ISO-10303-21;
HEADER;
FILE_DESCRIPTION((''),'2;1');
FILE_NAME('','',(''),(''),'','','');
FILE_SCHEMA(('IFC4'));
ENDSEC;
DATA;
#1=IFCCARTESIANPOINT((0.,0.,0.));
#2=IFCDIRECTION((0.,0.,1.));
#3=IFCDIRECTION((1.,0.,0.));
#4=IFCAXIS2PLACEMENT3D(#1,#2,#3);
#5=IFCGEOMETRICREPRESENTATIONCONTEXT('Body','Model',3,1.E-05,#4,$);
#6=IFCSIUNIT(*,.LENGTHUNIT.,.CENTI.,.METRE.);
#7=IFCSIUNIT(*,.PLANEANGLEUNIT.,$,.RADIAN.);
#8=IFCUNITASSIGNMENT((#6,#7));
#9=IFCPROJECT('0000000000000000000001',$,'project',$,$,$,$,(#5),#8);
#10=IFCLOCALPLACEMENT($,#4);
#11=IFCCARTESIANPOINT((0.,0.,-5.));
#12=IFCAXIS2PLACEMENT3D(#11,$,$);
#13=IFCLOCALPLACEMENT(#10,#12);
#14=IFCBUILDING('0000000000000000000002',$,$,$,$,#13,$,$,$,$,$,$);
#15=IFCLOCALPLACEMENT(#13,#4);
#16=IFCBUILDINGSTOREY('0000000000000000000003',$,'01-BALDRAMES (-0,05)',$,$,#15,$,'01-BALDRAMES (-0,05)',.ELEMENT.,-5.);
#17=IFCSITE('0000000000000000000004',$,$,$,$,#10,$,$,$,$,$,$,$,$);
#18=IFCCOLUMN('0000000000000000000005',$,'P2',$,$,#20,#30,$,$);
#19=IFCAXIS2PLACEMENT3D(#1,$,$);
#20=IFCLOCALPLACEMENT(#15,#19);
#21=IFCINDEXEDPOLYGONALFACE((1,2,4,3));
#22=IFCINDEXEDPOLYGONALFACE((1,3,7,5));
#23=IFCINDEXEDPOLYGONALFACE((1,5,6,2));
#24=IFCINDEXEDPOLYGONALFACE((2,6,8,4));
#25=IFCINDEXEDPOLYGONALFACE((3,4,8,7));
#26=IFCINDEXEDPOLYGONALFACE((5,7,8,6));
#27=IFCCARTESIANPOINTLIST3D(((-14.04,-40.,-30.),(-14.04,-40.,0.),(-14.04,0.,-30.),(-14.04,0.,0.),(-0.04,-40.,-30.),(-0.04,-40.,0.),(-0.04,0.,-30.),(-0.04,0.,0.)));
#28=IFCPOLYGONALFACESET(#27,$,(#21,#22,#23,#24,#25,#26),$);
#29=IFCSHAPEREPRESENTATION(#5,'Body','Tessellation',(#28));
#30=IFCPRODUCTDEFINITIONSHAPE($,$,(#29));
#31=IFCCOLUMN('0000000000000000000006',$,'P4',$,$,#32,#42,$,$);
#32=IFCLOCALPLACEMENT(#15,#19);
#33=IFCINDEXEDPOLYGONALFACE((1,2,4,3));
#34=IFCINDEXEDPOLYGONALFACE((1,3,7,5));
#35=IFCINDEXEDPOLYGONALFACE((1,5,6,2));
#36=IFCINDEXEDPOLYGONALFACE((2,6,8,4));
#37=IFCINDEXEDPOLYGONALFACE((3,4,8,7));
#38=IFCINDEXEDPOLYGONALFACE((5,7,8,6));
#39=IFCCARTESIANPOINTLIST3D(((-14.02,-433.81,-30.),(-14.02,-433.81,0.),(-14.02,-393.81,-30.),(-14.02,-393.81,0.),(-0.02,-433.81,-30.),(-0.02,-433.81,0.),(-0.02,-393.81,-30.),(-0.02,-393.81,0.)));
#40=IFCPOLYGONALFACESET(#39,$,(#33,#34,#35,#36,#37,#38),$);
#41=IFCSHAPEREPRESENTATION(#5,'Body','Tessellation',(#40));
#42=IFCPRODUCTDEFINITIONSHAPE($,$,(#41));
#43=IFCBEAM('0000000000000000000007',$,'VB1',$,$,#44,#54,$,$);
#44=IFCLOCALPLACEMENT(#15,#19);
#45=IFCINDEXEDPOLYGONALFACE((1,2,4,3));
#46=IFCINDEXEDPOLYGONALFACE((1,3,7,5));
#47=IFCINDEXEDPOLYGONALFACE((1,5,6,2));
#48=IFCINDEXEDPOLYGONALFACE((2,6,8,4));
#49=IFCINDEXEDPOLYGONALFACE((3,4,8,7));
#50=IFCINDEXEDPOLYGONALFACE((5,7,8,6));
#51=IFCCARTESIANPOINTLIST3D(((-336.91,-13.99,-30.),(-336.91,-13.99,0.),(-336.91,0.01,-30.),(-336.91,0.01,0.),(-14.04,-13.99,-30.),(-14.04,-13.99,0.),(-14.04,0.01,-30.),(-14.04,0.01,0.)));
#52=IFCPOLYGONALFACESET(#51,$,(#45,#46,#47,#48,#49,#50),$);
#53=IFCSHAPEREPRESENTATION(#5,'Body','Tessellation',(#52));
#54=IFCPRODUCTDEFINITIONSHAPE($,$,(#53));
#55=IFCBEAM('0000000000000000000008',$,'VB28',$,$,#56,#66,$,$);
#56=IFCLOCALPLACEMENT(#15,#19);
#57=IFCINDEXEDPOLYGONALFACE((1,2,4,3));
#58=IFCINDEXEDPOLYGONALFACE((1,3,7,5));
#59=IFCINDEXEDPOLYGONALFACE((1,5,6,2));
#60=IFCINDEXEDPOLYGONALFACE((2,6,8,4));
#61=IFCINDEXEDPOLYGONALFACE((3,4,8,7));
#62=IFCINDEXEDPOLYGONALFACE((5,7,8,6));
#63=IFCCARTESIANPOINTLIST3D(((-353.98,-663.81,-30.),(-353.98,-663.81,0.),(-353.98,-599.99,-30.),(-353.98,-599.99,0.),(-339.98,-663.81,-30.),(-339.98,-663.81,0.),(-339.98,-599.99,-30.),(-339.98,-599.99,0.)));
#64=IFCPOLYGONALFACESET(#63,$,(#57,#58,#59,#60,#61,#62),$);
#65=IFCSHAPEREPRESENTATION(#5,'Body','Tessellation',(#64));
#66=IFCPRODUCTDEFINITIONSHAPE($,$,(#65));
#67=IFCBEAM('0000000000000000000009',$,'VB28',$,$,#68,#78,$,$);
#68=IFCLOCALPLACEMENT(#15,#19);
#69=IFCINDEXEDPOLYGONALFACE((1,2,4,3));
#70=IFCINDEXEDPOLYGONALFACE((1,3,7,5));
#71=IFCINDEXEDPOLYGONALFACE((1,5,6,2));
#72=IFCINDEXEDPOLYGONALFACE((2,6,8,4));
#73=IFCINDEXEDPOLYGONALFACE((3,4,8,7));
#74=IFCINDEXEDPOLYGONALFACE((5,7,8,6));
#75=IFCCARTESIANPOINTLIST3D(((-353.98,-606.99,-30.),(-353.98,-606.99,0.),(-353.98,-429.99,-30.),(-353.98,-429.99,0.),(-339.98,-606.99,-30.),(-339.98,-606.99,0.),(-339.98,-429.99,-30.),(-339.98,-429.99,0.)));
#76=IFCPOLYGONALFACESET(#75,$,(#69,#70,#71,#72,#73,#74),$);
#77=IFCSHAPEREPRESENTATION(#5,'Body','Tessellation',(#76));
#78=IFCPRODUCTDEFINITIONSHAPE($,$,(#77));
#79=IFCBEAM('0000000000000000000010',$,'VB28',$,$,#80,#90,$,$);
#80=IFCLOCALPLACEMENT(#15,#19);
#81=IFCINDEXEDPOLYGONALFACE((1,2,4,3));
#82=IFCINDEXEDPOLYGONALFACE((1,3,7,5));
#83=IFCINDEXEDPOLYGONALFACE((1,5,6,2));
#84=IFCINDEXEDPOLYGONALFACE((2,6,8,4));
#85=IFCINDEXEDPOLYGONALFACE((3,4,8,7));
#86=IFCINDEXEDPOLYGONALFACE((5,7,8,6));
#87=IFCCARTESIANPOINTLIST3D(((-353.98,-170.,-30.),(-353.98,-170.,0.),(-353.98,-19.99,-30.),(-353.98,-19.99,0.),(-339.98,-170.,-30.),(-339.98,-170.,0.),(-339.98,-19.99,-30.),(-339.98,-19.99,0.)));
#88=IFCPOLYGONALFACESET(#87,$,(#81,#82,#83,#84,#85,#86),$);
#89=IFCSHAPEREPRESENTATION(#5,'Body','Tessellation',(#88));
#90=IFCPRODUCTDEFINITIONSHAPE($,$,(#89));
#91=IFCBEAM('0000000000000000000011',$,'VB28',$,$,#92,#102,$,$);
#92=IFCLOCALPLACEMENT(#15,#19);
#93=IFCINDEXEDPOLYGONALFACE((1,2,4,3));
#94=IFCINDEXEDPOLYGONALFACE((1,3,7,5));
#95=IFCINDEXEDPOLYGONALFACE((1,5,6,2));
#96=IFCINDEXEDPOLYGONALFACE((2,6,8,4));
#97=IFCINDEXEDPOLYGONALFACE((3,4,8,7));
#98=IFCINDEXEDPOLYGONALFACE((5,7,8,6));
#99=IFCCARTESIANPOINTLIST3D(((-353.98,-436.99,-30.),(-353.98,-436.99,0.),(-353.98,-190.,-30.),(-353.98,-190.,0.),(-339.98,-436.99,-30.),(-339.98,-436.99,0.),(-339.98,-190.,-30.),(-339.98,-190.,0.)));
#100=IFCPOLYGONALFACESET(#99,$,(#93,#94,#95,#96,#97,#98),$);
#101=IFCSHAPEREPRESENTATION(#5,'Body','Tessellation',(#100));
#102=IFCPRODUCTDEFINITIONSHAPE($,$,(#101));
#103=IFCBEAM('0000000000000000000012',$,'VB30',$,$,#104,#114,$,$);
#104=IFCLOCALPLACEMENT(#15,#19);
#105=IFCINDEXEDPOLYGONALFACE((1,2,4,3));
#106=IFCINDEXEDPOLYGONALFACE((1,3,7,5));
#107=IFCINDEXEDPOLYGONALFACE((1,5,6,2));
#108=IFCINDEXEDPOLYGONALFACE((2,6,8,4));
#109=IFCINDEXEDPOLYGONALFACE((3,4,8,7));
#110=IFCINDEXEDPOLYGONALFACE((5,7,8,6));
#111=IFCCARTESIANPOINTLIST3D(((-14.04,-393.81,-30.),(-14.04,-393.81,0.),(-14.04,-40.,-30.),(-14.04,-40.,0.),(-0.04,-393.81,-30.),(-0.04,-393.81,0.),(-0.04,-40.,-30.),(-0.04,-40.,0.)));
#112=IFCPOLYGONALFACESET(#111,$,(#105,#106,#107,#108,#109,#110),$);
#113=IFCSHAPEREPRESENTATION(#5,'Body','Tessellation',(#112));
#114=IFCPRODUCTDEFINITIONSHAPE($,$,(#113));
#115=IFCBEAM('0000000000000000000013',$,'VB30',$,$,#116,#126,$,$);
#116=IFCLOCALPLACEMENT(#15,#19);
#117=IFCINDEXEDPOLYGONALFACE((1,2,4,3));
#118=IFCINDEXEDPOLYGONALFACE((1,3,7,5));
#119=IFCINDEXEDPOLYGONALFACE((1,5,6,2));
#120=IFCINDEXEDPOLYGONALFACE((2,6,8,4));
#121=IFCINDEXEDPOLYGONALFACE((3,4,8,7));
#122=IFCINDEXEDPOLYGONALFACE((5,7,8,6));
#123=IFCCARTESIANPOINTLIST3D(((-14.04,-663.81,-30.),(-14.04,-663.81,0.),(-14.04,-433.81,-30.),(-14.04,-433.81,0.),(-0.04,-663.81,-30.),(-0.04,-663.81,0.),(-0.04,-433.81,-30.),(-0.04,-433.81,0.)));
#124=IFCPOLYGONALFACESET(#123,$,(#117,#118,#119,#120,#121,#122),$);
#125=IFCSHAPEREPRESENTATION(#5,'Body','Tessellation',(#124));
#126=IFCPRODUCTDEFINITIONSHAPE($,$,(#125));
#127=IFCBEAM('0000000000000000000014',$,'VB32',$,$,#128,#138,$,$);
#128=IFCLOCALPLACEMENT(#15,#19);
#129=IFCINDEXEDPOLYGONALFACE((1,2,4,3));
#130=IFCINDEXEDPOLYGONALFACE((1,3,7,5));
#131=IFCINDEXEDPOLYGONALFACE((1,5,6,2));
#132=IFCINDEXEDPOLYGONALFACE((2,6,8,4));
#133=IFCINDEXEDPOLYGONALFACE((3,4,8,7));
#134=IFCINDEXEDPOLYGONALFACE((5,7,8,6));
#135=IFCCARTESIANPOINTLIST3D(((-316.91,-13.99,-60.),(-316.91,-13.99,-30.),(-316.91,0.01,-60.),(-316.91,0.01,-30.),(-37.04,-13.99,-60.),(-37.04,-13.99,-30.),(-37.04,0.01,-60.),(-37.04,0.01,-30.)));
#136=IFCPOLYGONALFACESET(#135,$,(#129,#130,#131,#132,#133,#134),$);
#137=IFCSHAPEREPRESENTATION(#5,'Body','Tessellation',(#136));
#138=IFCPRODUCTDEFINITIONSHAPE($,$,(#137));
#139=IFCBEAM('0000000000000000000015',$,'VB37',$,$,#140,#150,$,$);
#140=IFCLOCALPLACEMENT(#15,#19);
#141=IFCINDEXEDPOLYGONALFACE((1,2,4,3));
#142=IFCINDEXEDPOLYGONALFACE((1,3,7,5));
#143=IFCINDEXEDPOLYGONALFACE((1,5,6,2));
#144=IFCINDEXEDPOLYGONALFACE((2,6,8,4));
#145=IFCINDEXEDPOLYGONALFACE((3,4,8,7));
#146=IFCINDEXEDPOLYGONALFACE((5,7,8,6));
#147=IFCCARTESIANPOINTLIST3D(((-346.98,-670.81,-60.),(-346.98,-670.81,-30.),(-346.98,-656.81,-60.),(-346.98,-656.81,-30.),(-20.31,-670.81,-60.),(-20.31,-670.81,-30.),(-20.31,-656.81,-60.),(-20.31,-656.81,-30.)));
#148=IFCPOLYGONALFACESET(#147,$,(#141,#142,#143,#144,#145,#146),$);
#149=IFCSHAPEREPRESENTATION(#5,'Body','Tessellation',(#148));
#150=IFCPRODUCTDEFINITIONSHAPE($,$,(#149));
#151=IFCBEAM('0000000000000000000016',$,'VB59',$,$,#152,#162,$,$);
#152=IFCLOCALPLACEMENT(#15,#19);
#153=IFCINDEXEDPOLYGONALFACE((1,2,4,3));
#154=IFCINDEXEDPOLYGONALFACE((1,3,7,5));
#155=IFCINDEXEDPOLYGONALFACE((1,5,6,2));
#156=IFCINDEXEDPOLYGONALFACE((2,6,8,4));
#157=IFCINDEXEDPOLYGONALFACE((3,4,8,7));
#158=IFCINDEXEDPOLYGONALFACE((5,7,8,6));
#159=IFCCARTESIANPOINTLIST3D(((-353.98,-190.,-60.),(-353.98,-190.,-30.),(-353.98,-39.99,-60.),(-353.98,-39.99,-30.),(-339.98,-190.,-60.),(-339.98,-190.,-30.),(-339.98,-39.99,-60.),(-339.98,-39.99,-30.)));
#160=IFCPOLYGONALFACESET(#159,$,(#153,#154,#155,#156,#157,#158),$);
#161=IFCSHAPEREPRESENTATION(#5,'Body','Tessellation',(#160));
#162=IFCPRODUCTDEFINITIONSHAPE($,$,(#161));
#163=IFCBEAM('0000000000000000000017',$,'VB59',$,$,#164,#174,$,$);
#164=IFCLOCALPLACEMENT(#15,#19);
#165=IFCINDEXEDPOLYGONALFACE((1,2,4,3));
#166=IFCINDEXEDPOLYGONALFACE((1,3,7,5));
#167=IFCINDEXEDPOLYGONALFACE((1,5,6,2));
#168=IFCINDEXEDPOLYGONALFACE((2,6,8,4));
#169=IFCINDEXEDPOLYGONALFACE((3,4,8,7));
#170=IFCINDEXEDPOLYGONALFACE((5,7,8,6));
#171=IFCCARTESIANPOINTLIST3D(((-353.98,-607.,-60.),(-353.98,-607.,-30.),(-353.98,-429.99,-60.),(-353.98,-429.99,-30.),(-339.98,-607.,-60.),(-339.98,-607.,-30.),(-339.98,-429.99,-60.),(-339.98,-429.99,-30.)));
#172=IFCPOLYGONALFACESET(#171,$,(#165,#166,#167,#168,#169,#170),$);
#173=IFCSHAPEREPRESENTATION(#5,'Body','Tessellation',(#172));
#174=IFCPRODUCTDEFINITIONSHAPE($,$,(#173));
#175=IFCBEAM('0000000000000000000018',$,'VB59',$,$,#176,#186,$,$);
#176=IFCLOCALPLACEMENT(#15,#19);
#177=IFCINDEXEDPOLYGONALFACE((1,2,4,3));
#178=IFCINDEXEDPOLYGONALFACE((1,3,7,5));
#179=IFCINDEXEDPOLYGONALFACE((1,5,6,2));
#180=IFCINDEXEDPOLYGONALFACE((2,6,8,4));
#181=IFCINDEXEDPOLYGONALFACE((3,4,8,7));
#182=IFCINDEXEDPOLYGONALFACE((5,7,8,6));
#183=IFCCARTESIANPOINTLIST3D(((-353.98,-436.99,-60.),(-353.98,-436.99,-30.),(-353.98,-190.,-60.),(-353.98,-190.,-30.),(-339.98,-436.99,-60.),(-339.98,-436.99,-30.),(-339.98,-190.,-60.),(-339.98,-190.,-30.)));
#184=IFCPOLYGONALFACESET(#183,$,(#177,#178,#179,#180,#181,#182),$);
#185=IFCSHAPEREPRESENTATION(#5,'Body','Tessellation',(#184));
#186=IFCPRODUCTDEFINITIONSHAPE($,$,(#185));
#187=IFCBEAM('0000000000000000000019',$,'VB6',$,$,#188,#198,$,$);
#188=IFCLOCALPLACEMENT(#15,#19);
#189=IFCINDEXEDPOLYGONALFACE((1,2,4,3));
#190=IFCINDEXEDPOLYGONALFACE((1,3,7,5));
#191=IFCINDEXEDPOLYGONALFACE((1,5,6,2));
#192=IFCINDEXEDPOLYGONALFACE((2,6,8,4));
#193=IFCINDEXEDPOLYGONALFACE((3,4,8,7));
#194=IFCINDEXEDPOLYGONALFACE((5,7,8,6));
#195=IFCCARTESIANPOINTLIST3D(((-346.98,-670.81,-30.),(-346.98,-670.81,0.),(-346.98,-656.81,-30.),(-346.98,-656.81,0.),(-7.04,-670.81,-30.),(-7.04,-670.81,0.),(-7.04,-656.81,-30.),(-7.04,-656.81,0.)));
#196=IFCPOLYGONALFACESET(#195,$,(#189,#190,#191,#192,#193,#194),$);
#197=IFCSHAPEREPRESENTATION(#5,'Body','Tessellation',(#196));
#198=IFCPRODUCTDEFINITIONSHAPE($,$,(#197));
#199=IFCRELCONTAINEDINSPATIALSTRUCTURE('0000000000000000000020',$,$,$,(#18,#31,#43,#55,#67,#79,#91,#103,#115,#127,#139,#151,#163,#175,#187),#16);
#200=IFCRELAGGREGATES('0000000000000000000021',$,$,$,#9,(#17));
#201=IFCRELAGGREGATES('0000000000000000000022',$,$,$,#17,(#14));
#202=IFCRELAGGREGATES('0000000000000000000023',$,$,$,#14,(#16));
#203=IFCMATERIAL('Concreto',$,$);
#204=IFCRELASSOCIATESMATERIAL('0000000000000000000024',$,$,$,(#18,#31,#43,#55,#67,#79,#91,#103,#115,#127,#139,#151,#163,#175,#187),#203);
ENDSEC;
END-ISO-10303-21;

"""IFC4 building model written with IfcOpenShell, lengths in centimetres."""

from ifc_helpers import new_model, si_unit, frame, origin_with_axes, origin_2d_with_axis, place, context, project, spatial, rectangle, extrude, material, element, save


model = new_model("IFC4")

# Units and contexts
model_context = context("Model", 3, precision=1e-05, world=origin_with_axes(), identifier="Body")
ifc_project = project(units=[si_unit("LENGTHUNIT", "METRE", prefix="CENTI"), si_unit("PLANEANGLEUNIT", "RADIAN")], contexts=[model_context])

# Site, building, storey
site_placement = place(None, origin_with_axes())
site = spatial("IfcSite", under=ifc_project, at=site_placement)
building_placement = place(site_placement, frame((0.0, 0.0, -5.0)))
building = spatial("IfcBuilding", under=site, at=building_placement)
storey_placement = place(building_placement, origin_with_axes())
storey = spatial("IfcBuildingStorey", under=building, at=storey_placement, Name="01-BALDRAMES (-0,05)", LongName="01-BALDRAMES (-0,05)", CompositionType="ELEMENT", Elevation=-5.0)

# Shared definitions
ifc_material = material(Name="Concreto")

# Columns
for number, where, z_axis, x_axis, name in (
    (1, (-7.04, -20.0, 0.0), (0.0, 0.0, 1.0), (1.0, 0.0, 0.0), "P2"),
    (2, (-7.02, -413.81, 0.0), (0.0, 0.0, 1.0), (1.0, 0.0, 0.0), "P4"),
):
    element("IfcColumn", number, at=place(storey_placement, frame(where, z_axis=z_axis, x_axis=x_axis)), inside=storey, material=ifc_material, Name=name, context=model_context, shape_type="SolidModel", body=[
        extrude(rectangle(XDim=14.0, YDim=40.0, at=origin_2d_with_axis()), origin_with_axes(), (0.0, 0.0, -1.0), 30.0),
    ])

# Beams
beam_1_placement = place(storey_placement, frame((-175.47, -6.99, 0.0), z_axis=(0.0, 0.0, 1.0), x_axis=(1.0, 0.0, 0.0)))
element("IfcBeam", 3, at=beam_1_placement, inside=storey, material=ifc_material, Name="VB1", context=model_context, shape_type="SolidModel", body=[
    extrude(rectangle(XDim=14.0, YDim=30.0, at=origin_2d_with_axis()), frame((-161.44, 0.0, -15.0), z_axis=(1.0, 0.0, 0.0), x_axis=(0.0, -1.0, 0.0)), (0.0, 0.0, 1.0), 322.87),
])
beam_2_placement = place(storey_placement, frame((-346.98, -631.9, 0.0), z_axis=(0.0, 0.0, 1.0), x_axis=(1.0, 0.0, 0.0)))
element("IfcBeam", 4, at=beam_2_placement, inside=storey, material=ifc_material, Name="VB28", context=model_context, shape_type="SolidModel", body=[
    extrude(rectangle(XDim=14.0, YDim=30.0, at=origin_2d_with_axis()), frame((0.0, -31.91, -15.0), z_axis=(0.0, 1.0, 0.0), x_axis=(1.0, 0.0, 0.0)), (0.0, 0.0, 1.0), 63.82),
])
beam_3_placement = place(storey_placement, frame((-346.98, -518.49, 0.0), z_axis=(0.0, 0.0, 1.0), x_axis=(1.0, 0.0, 0.0)))
element("IfcBeam", 5, at=beam_3_placement, inside=storey, material=ifc_material, Name="VB28", context=model_context, shape_type="SolidModel", body=[
    extrude(rectangle(XDim=14.0, YDim=30.0, at=origin_2d_with_axis()), frame((0.0, -88.5, -15.0), z_axis=(0.0, 1.0, 0.0), x_axis=(1.0, 0.0, 0.0)), (0.0, 0.0, 1.0), 177.0),
])
beam_4_placement = place(storey_placement, frame((-346.98, -95.0, 0.0), z_axis=(0.0, 0.0, 1.0), x_axis=(1.0, 0.0, 0.0)))
element("IfcBeam", 6, at=beam_4_placement, inside=storey, material=ifc_material, Name="VB28", context=model_context, shape_type="SolidModel", body=[
    extrude(rectangle(XDim=14.0, YDim=30.0, at=origin_2d_with_axis()), frame((0.0, -75.0, -15.0), z_axis=(0.0, 1.0, 0.0), x_axis=(-1.0, 0.0, 0.0)), (0.0, 0.0, 1.0), 150.01),
])
beam_5_placement = place(storey_placement, frame((-346.98, -313.5, 0.0), z_axis=(0.0, 0.0, 1.0), x_axis=(1.0, 0.0, 0.0)))
element("IfcBeam", 7, at=beam_5_placement, inside=storey, material=ifc_material, Name="VB28", context=model_context, shape_type="SolidModel", body=[
    extrude(rectangle(XDim=14.0, YDim=30.0, at=origin_2d_with_axis()), frame((0.0, -123.5, -15.0), z_axis=(0.0, 1.0, 0.0), x_axis=(-1.0, 0.0, 0.0)), (0.0, 0.0, 1.0), 246.99),
])
beam_6_placement = place(storey_placement, frame((-7.04, -216.91, 0.0), z_axis=(0.0, 0.0, 1.0), x_axis=(1.0, 0.0, 0.0)))
element("IfcBeam", 8, at=beam_6_placement, inside=storey, material=ifc_material, Name="VB30", context=model_context, shape_type="SolidModel", body=[
    extrude(rectangle(XDim=14.0, YDim=30.0, at=origin_2d_with_axis()), frame((0.0, -176.91, -15.0), z_axis=(0.0, 1.0, 0.0), x_axis=(1.0, 0.0, 0.0)), (0.0, 0.0, 1.0), 353.81),
])
beam_7_placement = place(storey_placement, frame((-7.04, -548.81, 0.0), z_axis=(0.0, 0.0, 1.0), x_axis=(1.0, 0.0, 0.0)))
element("IfcBeam", 9, at=beam_7_placement, inside=storey, material=ifc_material, Name="VB30", context=model_context, shape_type="SolidModel", body=[
    extrude(rectangle(XDim=14.0, YDim=30.0, at=origin_2d_with_axis()), frame((0.0, -115.0, -15.0), z_axis=(0.0, 1.0, 0.0), x_axis=(1.0, 0.0, 0.0)), (0.0, 0.0, 1.0), 230.0),
])
beam_8_placement = place(storey_placement, frame((-176.97, -6.99, -30.0), z_axis=(0.0, 0.0, 1.0), x_axis=(1.0, 0.0, 0.0)))
element("IfcBeam", 10, at=beam_8_placement, inside=storey, material=ifc_material, Name="VB32", context=model_context, shape_type="SolidModel", body=[
    extrude(rectangle(XDim=14.0, YDim=30.0, at=origin_2d_with_axis()), frame((-139.94, 0.0, -15.0), z_axis=(1.0, 0.0, 0.0), x_axis=(0.0, -1.0, 0.0)), (0.0, 0.0, 1.0), 279.87),
])
beam_9_placement = place(storey_placement, frame((-183.64, -663.81, -30.0), z_axis=(0.0, 0.0, 1.0), x_axis=(1.0, 0.0, 0.0)))
element("IfcBeam", 11, at=beam_9_placement, inside=storey, material=ifc_material, Name="VB37", context=model_context, shape_type="SolidModel", body=[
    extrude(rectangle(XDim=14.0, YDim=30.0, at=origin_2d_with_axis()), frame((-163.34, 0.0, -15.0), z_axis=(1.0, 0.0, 0.0), x_axis=(0.0, -1.0, 0.0)), (0.0, 0.0, 1.0), 326.67),
])
beam_10_placement = place(storey_placement, frame((-346.98, -115.0, -30.0), z_axis=(0.0, 0.0, 1.0), x_axis=(1.0, 0.0, 0.0)))
element("IfcBeam", 12, at=beam_10_placement, inside=storey, material=ifc_material, Name="VB59", context=model_context, shape_type="SolidModel", body=[
    extrude(rectangle(XDim=14.0, YDim=30.0, at=origin_2d_with_axis()), frame((0.0, -75.0, -15.0), z_axis=(0.0, 1.0, 0.0), x_axis=(-1.0, 0.0, 0.0)), (0.0, 0.0, 1.0), 150.01),
])
beam_11_placement = place(storey_placement, frame((-346.98, -518.5, -30.0), z_axis=(0.0, 0.0, 1.0), x_axis=(1.0, 0.0, 0.0)))
element("IfcBeam", 13, at=beam_11_placement, inside=storey, material=ifc_material, Name="VB59", context=model_context, shape_type="SolidModel", body=[
    extrude(rectangle(XDim=14.0, YDim=30.0, at=origin_2d_with_axis()), frame((0.0, -88.5, -15.0), z_axis=(0.0, 1.0, 0.0), x_axis=(1.0, 0.0, 0.0)), (0.0, 0.0, 1.0), 177.01),
])
beam_12_placement = place(storey_placement, frame((-346.98, -313.5, -30.0), z_axis=(0.0, 0.0, 1.0), x_axis=(1.0, 0.0, 0.0)))
element("IfcBeam", 14, at=beam_12_placement, inside=storey, material=ifc_material, Name="VB59", context=model_context, shape_type="SolidModel", body=[
    extrude(rectangle(XDim=14.0, YDim=30.0, at=origin_2d_with_axis()), frame((0.0, -123.5, -15.0), z_axis=(0.0, 1.0, 0.0), x_axis=(-1.0, 0.0, 0.0)), (0.0, 0.0, 1.0), 246.99),
])
beam_13_placement = place(storey_placement, frame((-177.01, -663.81, 0.0), z_axis=(0.0, 0.0, 1.0), x_axis=(1.0, 0.0, 0.0)))
element("IfcBeam", 15, at=beam_13_placement, inside=storey, material=ifc_material, Name="VB6", context=model_context, shape_type="SolidModel", body=[
    extrude(rectangle(XDim=14.0, YDim=30.0, at=origin_2d_with_axis()), frame((-169.97, 0.0, -15.0), z_axis=(1.0, 0.0, 0.0), x_axis=(0.0, -1.0, 0.0)), (0.0, 0.0, 1.0), 339.94),
])

save(model, "model.ifc")
